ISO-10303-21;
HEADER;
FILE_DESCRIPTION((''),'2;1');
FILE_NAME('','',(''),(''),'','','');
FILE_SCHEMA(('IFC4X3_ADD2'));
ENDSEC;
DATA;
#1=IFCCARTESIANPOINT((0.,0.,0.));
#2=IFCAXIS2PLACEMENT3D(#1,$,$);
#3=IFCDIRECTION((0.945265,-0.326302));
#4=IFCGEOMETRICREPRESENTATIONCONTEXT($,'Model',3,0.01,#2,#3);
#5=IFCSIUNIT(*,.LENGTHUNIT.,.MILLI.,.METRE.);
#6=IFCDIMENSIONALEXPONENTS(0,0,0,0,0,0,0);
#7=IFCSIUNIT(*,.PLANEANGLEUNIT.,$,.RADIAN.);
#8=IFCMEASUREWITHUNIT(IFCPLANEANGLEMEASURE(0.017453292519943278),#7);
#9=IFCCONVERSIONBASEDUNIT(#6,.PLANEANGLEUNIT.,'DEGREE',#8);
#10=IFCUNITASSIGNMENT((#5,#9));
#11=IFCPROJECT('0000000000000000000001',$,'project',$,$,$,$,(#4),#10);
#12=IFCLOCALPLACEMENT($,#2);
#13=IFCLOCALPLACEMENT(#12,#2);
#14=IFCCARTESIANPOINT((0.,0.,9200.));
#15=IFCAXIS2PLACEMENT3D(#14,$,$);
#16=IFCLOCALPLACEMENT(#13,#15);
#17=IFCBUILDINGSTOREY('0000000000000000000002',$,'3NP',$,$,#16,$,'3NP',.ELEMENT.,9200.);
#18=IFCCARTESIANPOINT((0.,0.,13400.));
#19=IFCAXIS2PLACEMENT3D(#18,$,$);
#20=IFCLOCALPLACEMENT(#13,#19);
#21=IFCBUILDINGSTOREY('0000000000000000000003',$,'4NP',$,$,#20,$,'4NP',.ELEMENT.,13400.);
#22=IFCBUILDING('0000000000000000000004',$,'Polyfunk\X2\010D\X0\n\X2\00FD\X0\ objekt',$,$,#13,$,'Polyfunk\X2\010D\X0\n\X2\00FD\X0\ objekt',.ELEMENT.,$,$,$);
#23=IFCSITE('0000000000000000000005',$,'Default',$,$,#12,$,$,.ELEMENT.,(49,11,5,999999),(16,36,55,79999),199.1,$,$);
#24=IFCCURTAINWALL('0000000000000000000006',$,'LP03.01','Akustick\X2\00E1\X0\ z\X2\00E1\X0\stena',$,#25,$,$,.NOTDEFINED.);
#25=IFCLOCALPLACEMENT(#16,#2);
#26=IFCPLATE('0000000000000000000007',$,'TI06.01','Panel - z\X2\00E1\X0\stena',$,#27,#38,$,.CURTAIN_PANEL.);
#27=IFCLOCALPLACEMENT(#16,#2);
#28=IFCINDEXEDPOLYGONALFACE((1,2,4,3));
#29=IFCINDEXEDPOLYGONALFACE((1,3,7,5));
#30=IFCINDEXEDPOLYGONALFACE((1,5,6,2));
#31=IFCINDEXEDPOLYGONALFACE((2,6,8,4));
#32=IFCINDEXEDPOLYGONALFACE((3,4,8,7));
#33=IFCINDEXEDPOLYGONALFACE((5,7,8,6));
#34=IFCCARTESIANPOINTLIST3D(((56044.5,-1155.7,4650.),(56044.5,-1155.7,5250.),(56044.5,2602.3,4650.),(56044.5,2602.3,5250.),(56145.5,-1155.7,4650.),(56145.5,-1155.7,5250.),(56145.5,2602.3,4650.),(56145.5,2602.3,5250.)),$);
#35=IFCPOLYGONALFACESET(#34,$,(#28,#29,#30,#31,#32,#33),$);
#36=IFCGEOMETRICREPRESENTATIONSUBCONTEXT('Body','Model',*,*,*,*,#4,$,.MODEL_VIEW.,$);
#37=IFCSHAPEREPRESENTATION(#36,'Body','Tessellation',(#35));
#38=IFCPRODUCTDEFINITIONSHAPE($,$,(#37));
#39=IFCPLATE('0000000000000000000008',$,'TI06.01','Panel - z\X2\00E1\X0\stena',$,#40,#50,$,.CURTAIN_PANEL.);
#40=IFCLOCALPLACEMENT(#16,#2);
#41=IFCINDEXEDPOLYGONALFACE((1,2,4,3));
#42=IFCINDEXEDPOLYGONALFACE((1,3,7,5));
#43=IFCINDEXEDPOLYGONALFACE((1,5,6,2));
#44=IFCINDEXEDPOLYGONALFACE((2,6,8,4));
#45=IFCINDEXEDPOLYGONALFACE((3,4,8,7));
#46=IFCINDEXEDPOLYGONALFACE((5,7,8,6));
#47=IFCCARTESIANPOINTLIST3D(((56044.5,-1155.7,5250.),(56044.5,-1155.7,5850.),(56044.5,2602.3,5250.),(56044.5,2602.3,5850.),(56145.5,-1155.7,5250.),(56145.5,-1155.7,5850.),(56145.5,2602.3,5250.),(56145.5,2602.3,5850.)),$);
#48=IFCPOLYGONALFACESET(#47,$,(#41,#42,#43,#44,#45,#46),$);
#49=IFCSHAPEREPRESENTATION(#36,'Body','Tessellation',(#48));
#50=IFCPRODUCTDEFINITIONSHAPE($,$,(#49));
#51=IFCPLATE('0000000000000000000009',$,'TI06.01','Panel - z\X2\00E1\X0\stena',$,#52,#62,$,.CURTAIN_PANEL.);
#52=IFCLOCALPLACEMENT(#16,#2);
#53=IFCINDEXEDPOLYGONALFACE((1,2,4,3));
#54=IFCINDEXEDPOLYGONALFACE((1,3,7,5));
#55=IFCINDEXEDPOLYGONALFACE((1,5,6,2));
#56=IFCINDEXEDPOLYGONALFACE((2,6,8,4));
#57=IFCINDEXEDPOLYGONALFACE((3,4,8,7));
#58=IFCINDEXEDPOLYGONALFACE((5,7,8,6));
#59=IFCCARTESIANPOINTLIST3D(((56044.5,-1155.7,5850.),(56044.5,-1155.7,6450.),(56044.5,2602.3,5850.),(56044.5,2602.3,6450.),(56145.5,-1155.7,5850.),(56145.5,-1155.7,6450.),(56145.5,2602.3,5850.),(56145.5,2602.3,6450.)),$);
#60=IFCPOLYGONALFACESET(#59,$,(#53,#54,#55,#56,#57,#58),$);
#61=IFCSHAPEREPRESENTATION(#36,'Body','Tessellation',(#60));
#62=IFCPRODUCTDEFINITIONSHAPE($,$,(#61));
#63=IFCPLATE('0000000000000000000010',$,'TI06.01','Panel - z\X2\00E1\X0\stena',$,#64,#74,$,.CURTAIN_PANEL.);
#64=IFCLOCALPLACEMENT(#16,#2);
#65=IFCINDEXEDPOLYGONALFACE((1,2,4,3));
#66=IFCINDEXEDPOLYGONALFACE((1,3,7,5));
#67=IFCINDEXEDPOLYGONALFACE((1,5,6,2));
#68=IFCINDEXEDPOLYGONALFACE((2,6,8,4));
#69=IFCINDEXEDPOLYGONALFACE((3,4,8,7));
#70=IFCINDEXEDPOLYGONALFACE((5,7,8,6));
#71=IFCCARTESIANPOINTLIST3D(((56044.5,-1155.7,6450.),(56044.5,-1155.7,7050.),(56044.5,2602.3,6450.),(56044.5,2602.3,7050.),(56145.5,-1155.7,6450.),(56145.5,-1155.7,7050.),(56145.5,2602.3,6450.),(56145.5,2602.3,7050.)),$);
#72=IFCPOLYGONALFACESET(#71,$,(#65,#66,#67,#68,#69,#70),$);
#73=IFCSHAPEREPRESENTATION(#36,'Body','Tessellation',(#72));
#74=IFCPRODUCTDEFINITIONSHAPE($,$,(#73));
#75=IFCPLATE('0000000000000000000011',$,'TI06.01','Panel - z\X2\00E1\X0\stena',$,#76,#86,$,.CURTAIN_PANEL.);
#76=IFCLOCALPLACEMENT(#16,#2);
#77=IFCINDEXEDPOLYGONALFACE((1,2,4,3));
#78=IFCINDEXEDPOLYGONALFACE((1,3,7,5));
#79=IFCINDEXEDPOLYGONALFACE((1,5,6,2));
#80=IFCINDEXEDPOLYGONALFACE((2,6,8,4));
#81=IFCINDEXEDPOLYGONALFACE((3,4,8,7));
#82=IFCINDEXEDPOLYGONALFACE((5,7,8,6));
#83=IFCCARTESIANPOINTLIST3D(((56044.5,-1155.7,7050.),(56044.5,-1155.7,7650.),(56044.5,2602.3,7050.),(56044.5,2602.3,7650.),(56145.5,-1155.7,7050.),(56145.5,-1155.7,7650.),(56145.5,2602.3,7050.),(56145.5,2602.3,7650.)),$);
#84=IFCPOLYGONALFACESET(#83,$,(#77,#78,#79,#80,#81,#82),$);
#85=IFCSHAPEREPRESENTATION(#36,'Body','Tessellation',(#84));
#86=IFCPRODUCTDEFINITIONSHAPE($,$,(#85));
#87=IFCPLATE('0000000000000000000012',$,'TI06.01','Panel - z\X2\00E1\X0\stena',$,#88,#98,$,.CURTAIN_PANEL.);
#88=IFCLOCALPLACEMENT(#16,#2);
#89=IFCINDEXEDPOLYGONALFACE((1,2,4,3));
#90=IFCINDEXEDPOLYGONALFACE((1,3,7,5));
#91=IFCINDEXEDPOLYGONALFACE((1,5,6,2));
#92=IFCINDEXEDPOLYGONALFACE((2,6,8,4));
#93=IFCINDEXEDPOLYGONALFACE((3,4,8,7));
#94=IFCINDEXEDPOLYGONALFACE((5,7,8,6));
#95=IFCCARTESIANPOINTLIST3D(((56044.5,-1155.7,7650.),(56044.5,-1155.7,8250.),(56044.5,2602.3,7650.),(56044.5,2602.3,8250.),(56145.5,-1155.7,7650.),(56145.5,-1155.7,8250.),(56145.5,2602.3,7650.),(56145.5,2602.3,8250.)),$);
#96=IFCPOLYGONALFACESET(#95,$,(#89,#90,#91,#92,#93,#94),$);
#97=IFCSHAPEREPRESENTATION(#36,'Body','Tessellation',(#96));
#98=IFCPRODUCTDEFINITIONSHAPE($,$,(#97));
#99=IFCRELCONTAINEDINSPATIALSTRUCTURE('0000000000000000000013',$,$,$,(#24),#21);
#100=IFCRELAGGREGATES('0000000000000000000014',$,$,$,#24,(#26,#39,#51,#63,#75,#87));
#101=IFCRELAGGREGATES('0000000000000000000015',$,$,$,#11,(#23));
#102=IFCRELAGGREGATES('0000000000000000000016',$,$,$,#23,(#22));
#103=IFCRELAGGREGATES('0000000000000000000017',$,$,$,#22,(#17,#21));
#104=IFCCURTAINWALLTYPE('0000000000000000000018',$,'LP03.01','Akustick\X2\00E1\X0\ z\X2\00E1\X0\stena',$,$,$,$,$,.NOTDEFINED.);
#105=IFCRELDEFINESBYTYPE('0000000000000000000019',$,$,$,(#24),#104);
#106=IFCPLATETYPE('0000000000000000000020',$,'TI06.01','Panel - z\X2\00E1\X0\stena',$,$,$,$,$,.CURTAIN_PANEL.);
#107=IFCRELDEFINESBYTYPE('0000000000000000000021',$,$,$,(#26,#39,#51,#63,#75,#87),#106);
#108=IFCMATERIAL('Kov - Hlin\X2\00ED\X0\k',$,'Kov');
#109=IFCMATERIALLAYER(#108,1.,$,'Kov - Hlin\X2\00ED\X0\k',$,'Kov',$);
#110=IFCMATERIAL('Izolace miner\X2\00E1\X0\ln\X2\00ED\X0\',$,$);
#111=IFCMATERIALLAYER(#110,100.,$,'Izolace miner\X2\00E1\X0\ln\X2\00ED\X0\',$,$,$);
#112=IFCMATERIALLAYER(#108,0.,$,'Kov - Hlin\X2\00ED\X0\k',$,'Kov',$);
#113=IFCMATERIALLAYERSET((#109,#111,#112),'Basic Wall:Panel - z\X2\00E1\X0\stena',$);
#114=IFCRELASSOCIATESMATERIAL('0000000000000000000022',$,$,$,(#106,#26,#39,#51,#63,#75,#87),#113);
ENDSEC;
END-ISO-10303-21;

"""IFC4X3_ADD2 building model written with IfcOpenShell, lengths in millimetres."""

from ifc_helpers import new_model, entity, si_unit, converted_unit, direction, frame, frame_2d, origin, place, context, subcontext, project, spatial, rectangle, extrude, material, layer, layer_set, layer_usage, type_object, element, aggregate, save


model = new_model("IFC4X3_ADD2")

# Units and contexts
model_context = context("Model", 3, precision=0.01, world=origin(), true_north=direction((0.945265, -0.326302)))
body_context = subcontext(model_context, "Body", "Model", "MODEL_VIEW")
ifc_project = project(units=[si_unit("LENGTHUNIT", "METRE", prefix="MILLI"), converted_unit("PLANEANGLEUNIT", "DEGREE", entity("IfcPlaneAngleMeasure", 0.017453292519943278), si_unit("PLANEANGLEUNIT", "RADIAN"), dimensions=[0, 0, 0, 0, 0, 0, 0])], contexts=[model_context])

# Site, building, storey
site_placement = place(None, origin())
site = spatial("IfcSite", under=ifc_project, at=site_placement, Name="Default", CompositionType="ELEMENT", RefLatitude=(49, 11, 5, 999999), RefLongitude=(16, 36, 55, 79999), RefElevation=199.1)
building_placement = place(site_placement, origin())
building = spatial("IfcBuilding", under=site, at=building_placement, Name="Polyfunkčný objekt", LongName="Polyfunkčný objekt", CompositionType="ELEMENT")
storey_1_placement = place(building_placement, frame((0.0, 0.0, 9200.0)))
storey_1 = spatial("IfcBuildingStorey", under=building, at=storey_1_placement, Name="3NP", LongName="3NP", CompositionType="ELEMENT", Elevation=9200.0)

# Shared definitions
storey_2_placement = place(building_placement, frame((0.0, 0.0, 13400.0)))
storey_2 = spatial("IfcBuildingStorey", under=building, at=storey_2_placement, Name="4NP", LongName="4NP", CompositionType="ELEMENT", Elevation=13400.0)

# Curtain wall
curtain_wall_type_1 = type_object("IfcCurtainWallType", Name="LP03.01", Description="Akustická zástena", PredefinedType="NOTDEFINED")
curtain_wall_1_placement = place(storey_2_placement, frame((0.0, 0.0, -13400.0)))
curtain_wall_1 = element("IfcCurtainWall", 1, at=curtain_wall_1_placement, inside=storey_2, type_object=curtain_wall_type_1, Name="LP03.01", Description="Akustická zástena", PredefinedType="NOTDEFINED")

# Plates
ifc_material_1 = material(Name="Kov - Hliník", Category="Kov")
ifc_layer_1 = layer(ifc_material_1, 1.0, Name="Kov - Hliník", Category="Kov")
ifc_material_2 = material(Name="Izolace minerální")
ifc_layer_2 = layer(ifc_material_2, 100.0, Name="Izolace minerální")
ifc_layer_3 = layer(ifc_material_1, 0.0, Name="Kov - Hliník", Category="Kov")
ifc_layer_set_1 = layer_set([ifc_layer_1, ifc_layer_2, ifc_layer_3], Name="Basic Wall:Panel - zástena")
plate_type = type_object("IfcPlateType", Name="TI06.01", Description="Panel - zástena", PredefinedType="CURTAIN_PANEL", material=ifc_layer_set_1)
ifc_layer_usage_1 = layer_usage(ifc_layer_set_1, "AXIS2", "NEGATIVE", 50.5)
plate_1_placement = place(storey_2_placement, frame((56095.0, -1155.7, 450.0), z_axis=(0.0, 0.0, 1.0), x_axis=(0.0, 1.0, 0.0)))
plate_1 = element("IfcPlate", 2, at=plate_1_placement, type_object=plate_type, material=ifc_layer_usage_1, Name="TI06.01", Description="Panel - zástena", PredefinedType="CURTAIN_PANEL", context=body_context, shape_type="SweptSolid", body=[
    extrude(rectangle(XDim=101.0, YDim=3758.1, at=frame_2d((0.0, 0.0), x_axis=(1.0, 0.0))), frame((1879.0, 0.0, 0.0), z_axis=(0.0, 0.0, 1.0), x_axis=(0.0, 1.0, 0.0)), (0.0, 0.0, 1.0), 600.0),
])
ifc_layer_usage_2 = layer_usage(ifc_layer_set_1, "AXIS2", "NEGATIVE", 50.5)
plate_2_placement = place(storey_2_placement, frame((56095.0, -1155.7, 1050.0), z_axis=(0.0, 0.0, 1.0), x_axis=(0.0, 1.0, 0.0)))
plate_2 = element("IfcPlate", 3, at=plate_2_placement, type_object=plate_type, material=ifc_layer_usage_2, Name="TI06.01", Description="Panel - zástena", PredefinedType="CURTAIN_PANEL", context=body_context, shape_type="SweptSolid", body=[
    extrude(rectangle(XDim=101.0, YDim=3758.1, at=frame_2d((0.0, 0.0), x_axis=(1.0, 0.0))), frame((1879.0, 0.0, 0.0), z_axis=(0.0, 0.0, 1.0), x_axis=(0.0, 1.0, 0.0)), (0.0, 0.0, 1.0), 600.0),
])
ifc_layer_usage_3 = layer_usage(ifc_layer_set_1, "AXIS2", "NEGATIVE", 50.5)
plate_3_placement = place(storey_2_placement, frame((56095.0, -1155.7, 1650.0), z_axis=(0.0, 0.0, 1.0), x_axis=(0.0, 1.0, 0.0)))
plate_3 = element("IfcPlate", 4, at=plate_3_placement, type_object=plate_type, material=ifc_layer_usage_3, Name="TI06.01", Description="Panel - zástena", PredefinedType="CURTAIN_PANEL", context=body_context, shape_type="SweptSolid", body=[
    extrude(rectangle(XDim=101.0, YDim=3758.1, at=frame_2d((0.0, 0.0), x_axis=(1.0, 0.0))), frame((1879.0, 0.0, 0.0), z_axis=(0.0, 0.0, 1.0), x_axis=(0.0, 1.0, 0.0)), (0.0, 0.0, 1.0), 600.0),
])
ifc_layer_usage_4 = layer_usage(ifc_layer_set_1, "AXIS2", "NEGATIVE", 50.5)
plate_4_placement = place(storey_2_placement, frame((56095.0, -1155.7, 2250.0), z_axis=(0.0, 0.0, 1.0), x_axis=(0.0, 1.0, 0.0)))
plate_4 = element("IfcPlate", 5, at=plate_4_placement, type_object=plate_type, material=ifc_layer_usage_4, Name="TI06.01", Description="Panel - zástena", PredefinedType="CURTAIN_PANEL", context=body_context, shape_type="SweptSolid", body=[
    extrude(rectangle(XDim=101.0, YDim=3758.1, at=frame_2d((0.0, 0.0), x_axis=(1.0, 0.0))), frame((1879.0, 0.0, 0.0), z_axis=(0.0, 0.0, 1.0), x_axis=(0.0, 1.0, 0.0)), (0.0, 0.0, 1.0), 600.0),
])
ifc_layer_usage_5 = layer_usage(ifc_layer_set_1, "AXIS2", "NEGATIVE", 50.5)
plate_5_placement = place(storey_2_placement, frame((56095.0, -1155.7, 2850.0), z_axis=(0.0, 0.0, 1.0), x_axis=(0.0, 1.0, 0.0)))
plate_5 = element("IfcPlate", 6, at=plate_5_placement, type_object=plate_type, material=ifc_layer_usage_5, Name="TI06.01", Description="Panel - zástena", PredefinedType="CURTAIN_PANEL", context=body_context, shape_type="SweptSolid", body=[
    extrude(rectangle(XDim=101.0, YDim=3758.1, at=frame_2d((0.0, 0.0), x_axis=(1.0, 0.0))), frame((1879.0, 0.0, 0.0), z_axis=(0.0, 0.0, 1.0), x_axis=(0.0, 1.0, 0.0)), (0.0, 0.0, 1.0), 600.0),
])
ifc_layer_usage_6 = layer_usage(ifc_layer_set_1, "AXIS2", "NEGATIVE", 50.5)
plate_6_placement = place(storey_2_placement, frame((56095.0, -1155.7, 3450.0), z_axis=(0.0, 0.0, 1.0), x_axis=(0.0, 1.0, 0.0)))
plate_6 = element("IfcPlate", 7, at=plate_6_placement, type_object=plate_type, material=ifc_layer_usage_6, Name="TI06.01", Description="Panel - zástena", PredefinedType="CURTAIN_PANEL", context=body_context, shape_type="SweptSolid", body=[
    extrude(rectangle(XDim=101.0, YDim=3758.1, at=frame_2d((0.0, 0.0), x_axis=(1.0, 0.0))), frame((1879.0, 0.0, 0.0), z_axis=(0.0, 0.0, 1.0), x_axis=(0.0, 1.0, 0.0)), (0.0, 0.0, 1.0), 600.0),
])
aggregate(curtain_wall_1, [plate_1, plate_2, plate_3, plate_4, plate_5, plate_6])

save(model, "model.ifc")
